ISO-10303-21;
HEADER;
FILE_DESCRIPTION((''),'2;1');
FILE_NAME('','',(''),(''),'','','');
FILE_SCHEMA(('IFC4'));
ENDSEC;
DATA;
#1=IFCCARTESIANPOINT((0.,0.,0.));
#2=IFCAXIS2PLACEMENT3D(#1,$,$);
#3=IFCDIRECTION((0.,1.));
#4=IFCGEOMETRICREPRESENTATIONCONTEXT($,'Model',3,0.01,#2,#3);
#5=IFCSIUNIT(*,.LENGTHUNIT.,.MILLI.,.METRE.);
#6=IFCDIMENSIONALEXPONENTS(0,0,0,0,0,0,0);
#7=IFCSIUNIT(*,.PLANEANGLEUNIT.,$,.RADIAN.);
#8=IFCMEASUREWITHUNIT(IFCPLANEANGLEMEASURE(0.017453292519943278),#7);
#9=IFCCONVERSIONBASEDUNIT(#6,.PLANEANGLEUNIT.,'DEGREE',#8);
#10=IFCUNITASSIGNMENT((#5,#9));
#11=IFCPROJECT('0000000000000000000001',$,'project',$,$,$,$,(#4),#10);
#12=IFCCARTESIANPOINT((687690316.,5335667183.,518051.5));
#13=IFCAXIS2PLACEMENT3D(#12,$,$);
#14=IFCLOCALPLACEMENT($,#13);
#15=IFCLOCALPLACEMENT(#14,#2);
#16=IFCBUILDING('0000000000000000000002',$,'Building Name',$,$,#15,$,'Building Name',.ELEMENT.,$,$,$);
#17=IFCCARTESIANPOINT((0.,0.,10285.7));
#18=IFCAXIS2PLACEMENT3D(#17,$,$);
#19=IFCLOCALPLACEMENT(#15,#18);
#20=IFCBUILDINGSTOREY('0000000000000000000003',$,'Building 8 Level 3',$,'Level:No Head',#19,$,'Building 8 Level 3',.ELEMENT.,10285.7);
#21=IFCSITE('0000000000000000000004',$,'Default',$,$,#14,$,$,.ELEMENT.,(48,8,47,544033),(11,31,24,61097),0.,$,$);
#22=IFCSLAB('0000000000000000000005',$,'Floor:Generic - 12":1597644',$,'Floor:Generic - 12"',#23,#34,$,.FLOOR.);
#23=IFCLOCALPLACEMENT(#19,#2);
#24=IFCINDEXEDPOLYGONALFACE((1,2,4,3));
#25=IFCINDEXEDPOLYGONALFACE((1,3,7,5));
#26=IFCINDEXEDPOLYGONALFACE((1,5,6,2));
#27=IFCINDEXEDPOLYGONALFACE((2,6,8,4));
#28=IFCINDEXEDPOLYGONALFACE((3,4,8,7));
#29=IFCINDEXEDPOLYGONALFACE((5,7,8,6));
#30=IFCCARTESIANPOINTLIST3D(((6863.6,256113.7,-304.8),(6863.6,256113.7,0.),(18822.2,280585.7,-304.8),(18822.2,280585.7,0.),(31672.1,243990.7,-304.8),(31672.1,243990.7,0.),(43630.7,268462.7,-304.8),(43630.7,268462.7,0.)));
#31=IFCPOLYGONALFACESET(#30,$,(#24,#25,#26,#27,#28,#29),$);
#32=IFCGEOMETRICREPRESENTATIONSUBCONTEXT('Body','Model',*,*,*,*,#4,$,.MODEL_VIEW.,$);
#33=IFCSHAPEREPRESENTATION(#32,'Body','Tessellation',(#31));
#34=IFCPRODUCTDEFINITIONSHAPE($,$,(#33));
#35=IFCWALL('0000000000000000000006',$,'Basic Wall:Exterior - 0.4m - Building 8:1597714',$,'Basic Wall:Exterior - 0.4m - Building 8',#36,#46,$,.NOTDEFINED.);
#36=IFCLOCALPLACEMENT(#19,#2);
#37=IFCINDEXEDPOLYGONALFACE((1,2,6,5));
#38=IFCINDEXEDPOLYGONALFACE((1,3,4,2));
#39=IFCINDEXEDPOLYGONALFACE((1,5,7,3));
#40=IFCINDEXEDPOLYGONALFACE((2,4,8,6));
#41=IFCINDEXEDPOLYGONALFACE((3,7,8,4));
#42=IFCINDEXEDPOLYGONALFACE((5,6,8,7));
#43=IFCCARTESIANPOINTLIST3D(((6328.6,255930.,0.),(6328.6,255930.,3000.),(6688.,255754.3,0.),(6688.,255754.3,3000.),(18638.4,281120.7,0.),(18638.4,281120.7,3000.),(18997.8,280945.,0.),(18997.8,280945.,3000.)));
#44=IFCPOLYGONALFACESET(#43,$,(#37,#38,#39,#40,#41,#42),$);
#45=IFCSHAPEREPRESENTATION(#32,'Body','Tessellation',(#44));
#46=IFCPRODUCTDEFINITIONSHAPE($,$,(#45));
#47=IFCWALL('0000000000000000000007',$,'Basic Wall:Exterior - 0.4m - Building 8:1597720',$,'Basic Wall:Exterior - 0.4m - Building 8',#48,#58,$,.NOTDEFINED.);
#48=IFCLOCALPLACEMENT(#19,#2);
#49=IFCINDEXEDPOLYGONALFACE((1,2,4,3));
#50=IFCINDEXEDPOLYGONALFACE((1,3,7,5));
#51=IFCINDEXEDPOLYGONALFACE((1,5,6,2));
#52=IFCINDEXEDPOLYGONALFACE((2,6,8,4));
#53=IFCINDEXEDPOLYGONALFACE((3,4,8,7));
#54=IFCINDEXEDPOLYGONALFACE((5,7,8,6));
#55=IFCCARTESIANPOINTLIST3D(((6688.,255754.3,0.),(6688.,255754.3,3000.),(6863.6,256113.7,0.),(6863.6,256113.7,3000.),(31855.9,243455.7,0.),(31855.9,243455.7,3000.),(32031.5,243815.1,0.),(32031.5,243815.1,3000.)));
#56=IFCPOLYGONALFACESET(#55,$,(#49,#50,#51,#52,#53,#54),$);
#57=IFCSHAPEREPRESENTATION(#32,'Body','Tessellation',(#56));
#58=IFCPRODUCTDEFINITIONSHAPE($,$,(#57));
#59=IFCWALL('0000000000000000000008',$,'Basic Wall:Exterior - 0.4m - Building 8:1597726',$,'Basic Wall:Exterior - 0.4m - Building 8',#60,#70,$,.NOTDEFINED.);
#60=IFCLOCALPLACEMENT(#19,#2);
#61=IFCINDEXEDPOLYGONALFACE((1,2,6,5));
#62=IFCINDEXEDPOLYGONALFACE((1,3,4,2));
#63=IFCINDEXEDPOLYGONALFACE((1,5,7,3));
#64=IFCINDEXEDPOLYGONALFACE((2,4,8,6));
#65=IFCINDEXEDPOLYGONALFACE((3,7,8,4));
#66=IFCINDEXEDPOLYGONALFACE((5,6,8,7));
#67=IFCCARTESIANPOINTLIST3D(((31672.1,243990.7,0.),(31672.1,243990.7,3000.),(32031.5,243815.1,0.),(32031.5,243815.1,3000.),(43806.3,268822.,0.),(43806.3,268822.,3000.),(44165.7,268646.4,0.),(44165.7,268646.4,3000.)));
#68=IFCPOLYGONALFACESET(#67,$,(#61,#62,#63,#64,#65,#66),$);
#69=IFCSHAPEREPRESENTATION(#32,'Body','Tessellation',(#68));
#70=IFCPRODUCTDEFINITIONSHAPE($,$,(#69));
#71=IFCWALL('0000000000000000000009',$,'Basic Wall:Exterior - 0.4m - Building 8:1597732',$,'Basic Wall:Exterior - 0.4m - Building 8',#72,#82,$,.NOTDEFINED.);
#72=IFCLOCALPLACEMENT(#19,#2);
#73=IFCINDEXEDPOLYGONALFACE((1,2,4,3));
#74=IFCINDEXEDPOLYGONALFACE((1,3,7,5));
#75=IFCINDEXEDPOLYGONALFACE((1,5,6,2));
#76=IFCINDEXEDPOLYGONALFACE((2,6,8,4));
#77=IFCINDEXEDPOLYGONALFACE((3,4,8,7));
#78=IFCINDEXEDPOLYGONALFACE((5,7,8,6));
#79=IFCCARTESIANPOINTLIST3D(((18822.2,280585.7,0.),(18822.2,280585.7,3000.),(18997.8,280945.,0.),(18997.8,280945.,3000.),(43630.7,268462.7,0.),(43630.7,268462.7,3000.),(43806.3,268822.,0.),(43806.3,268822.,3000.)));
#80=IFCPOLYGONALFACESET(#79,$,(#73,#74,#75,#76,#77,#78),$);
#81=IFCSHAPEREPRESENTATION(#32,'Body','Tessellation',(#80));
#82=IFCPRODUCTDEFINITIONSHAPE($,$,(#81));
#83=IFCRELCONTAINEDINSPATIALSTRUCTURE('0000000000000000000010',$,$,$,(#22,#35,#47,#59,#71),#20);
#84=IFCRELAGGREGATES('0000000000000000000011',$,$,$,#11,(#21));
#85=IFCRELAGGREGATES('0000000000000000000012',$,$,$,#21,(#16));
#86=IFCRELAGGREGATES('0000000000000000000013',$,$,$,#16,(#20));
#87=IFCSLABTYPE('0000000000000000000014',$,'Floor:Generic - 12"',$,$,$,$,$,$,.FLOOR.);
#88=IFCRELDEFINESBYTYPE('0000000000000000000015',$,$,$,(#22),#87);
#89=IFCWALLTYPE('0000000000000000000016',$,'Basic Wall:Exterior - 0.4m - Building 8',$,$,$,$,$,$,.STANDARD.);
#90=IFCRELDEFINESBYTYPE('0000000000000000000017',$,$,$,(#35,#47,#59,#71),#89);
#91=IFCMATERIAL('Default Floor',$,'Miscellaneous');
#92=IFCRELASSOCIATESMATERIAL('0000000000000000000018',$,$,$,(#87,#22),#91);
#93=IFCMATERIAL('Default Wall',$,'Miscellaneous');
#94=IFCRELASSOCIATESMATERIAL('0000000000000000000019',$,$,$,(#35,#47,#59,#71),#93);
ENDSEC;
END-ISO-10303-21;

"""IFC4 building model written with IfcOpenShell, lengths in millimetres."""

from ifc_helpers import new_model, entity, si_unit, converted_unit, direction, frame, origin, place, context, subcontext, project, spatial, indexed_curve, outline, extrude, material, type_object, element, save


model = new_model("IFC4")

# Units and contexts
model_context = context("Model", 3, precision=0.01, world=origin(), true_north=direction((0.0, 1.0)))
body_context = subcontext(model_context, "Body", "Model", "MODEL_VIEW")
ifc_project = project(units=[si_unit("LENGTHUNIT", "METRE", prefix="MILLI"), converted_unit("PLANEANGLEUNIT", "DEGREE", entity("IfcPlaneAngleMeasure", 0.017453292519943278), si_unit("PLANEANGLEUNIT", "RADIAN"), dimensions=[0, 0, 0, 0, 0, 0, 0])], contexts=[model_context])

# Site, building, storey
site_placement = place(None, frame((687690316.0, 5335667183.0, 518051.5)))
site = spatial("IfcSite", under=ifc_project, at=site_placement, Name="Default", CompositionType="ELEMENT", RefLatitude=(48, 8, 47, 544033), RefLongitude=(11, 31, 24, 61097), RefElevation=0.0)
building_placement = place(site_placement, origin())
building = spatial("IfcBuilding", under=site, at=building_placement, Name="Building Name", LongName="Building Name", CompositionType="ELEMENT")
storey_placement = place(building_placement, frame((0.0, 0.0, 10285.7)))
storey = spatial("IfcBuildingStorey", under=building, at=storey_placement, Name="Building 8 Level 3", ObjectType="Level:No Head", LongName="Building 8 Level 3", CompositionType="ELEMENT", Elevation=10285.7)

# Slab
ifc_material_1 = material(Name="Default Floor", Category="Miscellaneous")
slab_type = type_object("IfcSlabType", Name="Floor:Generic - 12\"", PredefinedType="FLOOR", material=ifc_material_1)
slab_placement = place(storey_placement, origin())
element("IfcSlab", 1, at=slab_placement, inside=storey, type_object=slab_type, material=ifc_material_1, Name="Floor:Generic - 12\":1597644", ObjectType="Floor:Generic - 12\"", PredefinedType="FLOOR", context=body_context, shape_type="SweptSolid", body=[
    extrude(outline(indexed_curve([(-13806.1, -13618.8), (13806.1, -13618.8), (13806.1, 13618.8), (-13806.1, 13618.8), (-13806.1, -13618.8)], self_intersect=False)), frame((25247.1, 262288.2, 0.0), z_axis=(0.0, 0.0, -1.0), x_axis=(0.898464, -0.439046, 0.0)), (0.0, 0.0, 1.0), 304.8),
])

# Walls
ifc_material_2 = material(Name="Default Wall", Category="Miscellaneous")
wall_type = type_object("IfcWallType", Name="Basic Wall:Exterior - 0.4m - Building 8", PredefinedType="STANDARD")
wall_1_placement = place(storey_placement, frame((18818.1, 281032.9, 0.0), z_axis=(0.0, 0.0, 1.0), x_axis=(-0.439046, -0.898464, 0.0)))
element("IfcWall", 2, at=wall_1_placement, inside=storey, type_object=wall_type, material=ifc_material_2, Name="Basic Wall:Exterior - 0.4m - Building 8:1597714", ObjectType="Basic Wall:Exterior - 0.4m - Building 8", PredefinedType="NOTDEFINED", context=body_context, shape_type="SweptSolid", body=[
    extrude(outline(indexed_curve([(28037.5, 200.0), (0.0, 200.0), (0.0, -200.0), (28037.5, -200.0), (28037.5, 200.0)], self_intersect=False)), origin(), (0.0, 0.0, 1.0), 3000.0),
])
wall_2_placement = place(storey_placement, frame((6775.8, 255934.0, 0.0), z_axis=(0.0, 0.0, 1.0), x_axis=(0.898464, -0.439046, 0.0)))
element("IfcWall", 3, at=wall_2_placement, inside=storey, type_object=wall_type, material=ifc_material_2, Name="Basic Wall:Exterior - 0.4m - Building 8:1597720", ObjectType="Basic Wall:Exterior - 0.4m - Building 8", PredefinedType="NOTDEFINED", context=body_context, shape_type="SweptSolid", body=[
    extrude(outline(indexed_curve([(28012.1, 200.0), (0.0, 200.0), (0.0, -200.0), (28012.1, -200.0), (28012.1, 200.0)], self_intersect=False)), origin(), (0.0, 0.0, 1.0), 3000.0),
])
wall_3_placement = place(storey_placement, frame((31851.8, 243902.9, 0.0), z_axis=(0.0, 0.0, 1.0), x_axis=(0.439046, 0.898464, 0.0)))
element("IfcWall", 4, at=wall_3_placement, inside=storey, type_object=wall_type, material=ifc_material_2, Name="Basic Wall:Exterior - 0.4m - Building 8:1597726", ObjectType="Basic Wall:Exterior - 0.4m - Building 8", PredefinedType="NOTDEFINED", context=body_context, shape_type="SweptSolid", body=[
    extrude(outline(indexed_curve([(27637.5, 200.0), (0.0, 200.0), (0.0, -200.0), (27637.5, -200.0), (27637.5, 200.0)], self_intersect=False)), origin(), (0.0, 0.0, 1.0), 3000.0),
])
wall_4_placement = place(storey_placement, frame((43718.5, 268642.3, 0.0), z_axis=(0.0, 0.0, 1.0), x_axis=(-0.898464, 0.439046, 0.0)))
element("IfcWall", 5, at=wall_4_placement, inside=storey, type_object=wall_type, material=ifc_material_2, Name="Basic Wall:Exterior - 0.4m - Building 8:1597732", ObjectType="Basic Wall:Exterior - 0.4m - Building 8", PredefinedType="NOTDEFINED", context=body_context, shape_type="SweptSolid", body=[
    extrude(outline(indexed_curve([(27612.1, 200.0), (0.0, 200.0), (0.0, -200.0), (27612.1, -200.0), (27612.1, 200.0)], self_intersect=False)), origin(), (0.0, 0.0, 1.0), 3000.0),
])

save(model, "model.ifc")
